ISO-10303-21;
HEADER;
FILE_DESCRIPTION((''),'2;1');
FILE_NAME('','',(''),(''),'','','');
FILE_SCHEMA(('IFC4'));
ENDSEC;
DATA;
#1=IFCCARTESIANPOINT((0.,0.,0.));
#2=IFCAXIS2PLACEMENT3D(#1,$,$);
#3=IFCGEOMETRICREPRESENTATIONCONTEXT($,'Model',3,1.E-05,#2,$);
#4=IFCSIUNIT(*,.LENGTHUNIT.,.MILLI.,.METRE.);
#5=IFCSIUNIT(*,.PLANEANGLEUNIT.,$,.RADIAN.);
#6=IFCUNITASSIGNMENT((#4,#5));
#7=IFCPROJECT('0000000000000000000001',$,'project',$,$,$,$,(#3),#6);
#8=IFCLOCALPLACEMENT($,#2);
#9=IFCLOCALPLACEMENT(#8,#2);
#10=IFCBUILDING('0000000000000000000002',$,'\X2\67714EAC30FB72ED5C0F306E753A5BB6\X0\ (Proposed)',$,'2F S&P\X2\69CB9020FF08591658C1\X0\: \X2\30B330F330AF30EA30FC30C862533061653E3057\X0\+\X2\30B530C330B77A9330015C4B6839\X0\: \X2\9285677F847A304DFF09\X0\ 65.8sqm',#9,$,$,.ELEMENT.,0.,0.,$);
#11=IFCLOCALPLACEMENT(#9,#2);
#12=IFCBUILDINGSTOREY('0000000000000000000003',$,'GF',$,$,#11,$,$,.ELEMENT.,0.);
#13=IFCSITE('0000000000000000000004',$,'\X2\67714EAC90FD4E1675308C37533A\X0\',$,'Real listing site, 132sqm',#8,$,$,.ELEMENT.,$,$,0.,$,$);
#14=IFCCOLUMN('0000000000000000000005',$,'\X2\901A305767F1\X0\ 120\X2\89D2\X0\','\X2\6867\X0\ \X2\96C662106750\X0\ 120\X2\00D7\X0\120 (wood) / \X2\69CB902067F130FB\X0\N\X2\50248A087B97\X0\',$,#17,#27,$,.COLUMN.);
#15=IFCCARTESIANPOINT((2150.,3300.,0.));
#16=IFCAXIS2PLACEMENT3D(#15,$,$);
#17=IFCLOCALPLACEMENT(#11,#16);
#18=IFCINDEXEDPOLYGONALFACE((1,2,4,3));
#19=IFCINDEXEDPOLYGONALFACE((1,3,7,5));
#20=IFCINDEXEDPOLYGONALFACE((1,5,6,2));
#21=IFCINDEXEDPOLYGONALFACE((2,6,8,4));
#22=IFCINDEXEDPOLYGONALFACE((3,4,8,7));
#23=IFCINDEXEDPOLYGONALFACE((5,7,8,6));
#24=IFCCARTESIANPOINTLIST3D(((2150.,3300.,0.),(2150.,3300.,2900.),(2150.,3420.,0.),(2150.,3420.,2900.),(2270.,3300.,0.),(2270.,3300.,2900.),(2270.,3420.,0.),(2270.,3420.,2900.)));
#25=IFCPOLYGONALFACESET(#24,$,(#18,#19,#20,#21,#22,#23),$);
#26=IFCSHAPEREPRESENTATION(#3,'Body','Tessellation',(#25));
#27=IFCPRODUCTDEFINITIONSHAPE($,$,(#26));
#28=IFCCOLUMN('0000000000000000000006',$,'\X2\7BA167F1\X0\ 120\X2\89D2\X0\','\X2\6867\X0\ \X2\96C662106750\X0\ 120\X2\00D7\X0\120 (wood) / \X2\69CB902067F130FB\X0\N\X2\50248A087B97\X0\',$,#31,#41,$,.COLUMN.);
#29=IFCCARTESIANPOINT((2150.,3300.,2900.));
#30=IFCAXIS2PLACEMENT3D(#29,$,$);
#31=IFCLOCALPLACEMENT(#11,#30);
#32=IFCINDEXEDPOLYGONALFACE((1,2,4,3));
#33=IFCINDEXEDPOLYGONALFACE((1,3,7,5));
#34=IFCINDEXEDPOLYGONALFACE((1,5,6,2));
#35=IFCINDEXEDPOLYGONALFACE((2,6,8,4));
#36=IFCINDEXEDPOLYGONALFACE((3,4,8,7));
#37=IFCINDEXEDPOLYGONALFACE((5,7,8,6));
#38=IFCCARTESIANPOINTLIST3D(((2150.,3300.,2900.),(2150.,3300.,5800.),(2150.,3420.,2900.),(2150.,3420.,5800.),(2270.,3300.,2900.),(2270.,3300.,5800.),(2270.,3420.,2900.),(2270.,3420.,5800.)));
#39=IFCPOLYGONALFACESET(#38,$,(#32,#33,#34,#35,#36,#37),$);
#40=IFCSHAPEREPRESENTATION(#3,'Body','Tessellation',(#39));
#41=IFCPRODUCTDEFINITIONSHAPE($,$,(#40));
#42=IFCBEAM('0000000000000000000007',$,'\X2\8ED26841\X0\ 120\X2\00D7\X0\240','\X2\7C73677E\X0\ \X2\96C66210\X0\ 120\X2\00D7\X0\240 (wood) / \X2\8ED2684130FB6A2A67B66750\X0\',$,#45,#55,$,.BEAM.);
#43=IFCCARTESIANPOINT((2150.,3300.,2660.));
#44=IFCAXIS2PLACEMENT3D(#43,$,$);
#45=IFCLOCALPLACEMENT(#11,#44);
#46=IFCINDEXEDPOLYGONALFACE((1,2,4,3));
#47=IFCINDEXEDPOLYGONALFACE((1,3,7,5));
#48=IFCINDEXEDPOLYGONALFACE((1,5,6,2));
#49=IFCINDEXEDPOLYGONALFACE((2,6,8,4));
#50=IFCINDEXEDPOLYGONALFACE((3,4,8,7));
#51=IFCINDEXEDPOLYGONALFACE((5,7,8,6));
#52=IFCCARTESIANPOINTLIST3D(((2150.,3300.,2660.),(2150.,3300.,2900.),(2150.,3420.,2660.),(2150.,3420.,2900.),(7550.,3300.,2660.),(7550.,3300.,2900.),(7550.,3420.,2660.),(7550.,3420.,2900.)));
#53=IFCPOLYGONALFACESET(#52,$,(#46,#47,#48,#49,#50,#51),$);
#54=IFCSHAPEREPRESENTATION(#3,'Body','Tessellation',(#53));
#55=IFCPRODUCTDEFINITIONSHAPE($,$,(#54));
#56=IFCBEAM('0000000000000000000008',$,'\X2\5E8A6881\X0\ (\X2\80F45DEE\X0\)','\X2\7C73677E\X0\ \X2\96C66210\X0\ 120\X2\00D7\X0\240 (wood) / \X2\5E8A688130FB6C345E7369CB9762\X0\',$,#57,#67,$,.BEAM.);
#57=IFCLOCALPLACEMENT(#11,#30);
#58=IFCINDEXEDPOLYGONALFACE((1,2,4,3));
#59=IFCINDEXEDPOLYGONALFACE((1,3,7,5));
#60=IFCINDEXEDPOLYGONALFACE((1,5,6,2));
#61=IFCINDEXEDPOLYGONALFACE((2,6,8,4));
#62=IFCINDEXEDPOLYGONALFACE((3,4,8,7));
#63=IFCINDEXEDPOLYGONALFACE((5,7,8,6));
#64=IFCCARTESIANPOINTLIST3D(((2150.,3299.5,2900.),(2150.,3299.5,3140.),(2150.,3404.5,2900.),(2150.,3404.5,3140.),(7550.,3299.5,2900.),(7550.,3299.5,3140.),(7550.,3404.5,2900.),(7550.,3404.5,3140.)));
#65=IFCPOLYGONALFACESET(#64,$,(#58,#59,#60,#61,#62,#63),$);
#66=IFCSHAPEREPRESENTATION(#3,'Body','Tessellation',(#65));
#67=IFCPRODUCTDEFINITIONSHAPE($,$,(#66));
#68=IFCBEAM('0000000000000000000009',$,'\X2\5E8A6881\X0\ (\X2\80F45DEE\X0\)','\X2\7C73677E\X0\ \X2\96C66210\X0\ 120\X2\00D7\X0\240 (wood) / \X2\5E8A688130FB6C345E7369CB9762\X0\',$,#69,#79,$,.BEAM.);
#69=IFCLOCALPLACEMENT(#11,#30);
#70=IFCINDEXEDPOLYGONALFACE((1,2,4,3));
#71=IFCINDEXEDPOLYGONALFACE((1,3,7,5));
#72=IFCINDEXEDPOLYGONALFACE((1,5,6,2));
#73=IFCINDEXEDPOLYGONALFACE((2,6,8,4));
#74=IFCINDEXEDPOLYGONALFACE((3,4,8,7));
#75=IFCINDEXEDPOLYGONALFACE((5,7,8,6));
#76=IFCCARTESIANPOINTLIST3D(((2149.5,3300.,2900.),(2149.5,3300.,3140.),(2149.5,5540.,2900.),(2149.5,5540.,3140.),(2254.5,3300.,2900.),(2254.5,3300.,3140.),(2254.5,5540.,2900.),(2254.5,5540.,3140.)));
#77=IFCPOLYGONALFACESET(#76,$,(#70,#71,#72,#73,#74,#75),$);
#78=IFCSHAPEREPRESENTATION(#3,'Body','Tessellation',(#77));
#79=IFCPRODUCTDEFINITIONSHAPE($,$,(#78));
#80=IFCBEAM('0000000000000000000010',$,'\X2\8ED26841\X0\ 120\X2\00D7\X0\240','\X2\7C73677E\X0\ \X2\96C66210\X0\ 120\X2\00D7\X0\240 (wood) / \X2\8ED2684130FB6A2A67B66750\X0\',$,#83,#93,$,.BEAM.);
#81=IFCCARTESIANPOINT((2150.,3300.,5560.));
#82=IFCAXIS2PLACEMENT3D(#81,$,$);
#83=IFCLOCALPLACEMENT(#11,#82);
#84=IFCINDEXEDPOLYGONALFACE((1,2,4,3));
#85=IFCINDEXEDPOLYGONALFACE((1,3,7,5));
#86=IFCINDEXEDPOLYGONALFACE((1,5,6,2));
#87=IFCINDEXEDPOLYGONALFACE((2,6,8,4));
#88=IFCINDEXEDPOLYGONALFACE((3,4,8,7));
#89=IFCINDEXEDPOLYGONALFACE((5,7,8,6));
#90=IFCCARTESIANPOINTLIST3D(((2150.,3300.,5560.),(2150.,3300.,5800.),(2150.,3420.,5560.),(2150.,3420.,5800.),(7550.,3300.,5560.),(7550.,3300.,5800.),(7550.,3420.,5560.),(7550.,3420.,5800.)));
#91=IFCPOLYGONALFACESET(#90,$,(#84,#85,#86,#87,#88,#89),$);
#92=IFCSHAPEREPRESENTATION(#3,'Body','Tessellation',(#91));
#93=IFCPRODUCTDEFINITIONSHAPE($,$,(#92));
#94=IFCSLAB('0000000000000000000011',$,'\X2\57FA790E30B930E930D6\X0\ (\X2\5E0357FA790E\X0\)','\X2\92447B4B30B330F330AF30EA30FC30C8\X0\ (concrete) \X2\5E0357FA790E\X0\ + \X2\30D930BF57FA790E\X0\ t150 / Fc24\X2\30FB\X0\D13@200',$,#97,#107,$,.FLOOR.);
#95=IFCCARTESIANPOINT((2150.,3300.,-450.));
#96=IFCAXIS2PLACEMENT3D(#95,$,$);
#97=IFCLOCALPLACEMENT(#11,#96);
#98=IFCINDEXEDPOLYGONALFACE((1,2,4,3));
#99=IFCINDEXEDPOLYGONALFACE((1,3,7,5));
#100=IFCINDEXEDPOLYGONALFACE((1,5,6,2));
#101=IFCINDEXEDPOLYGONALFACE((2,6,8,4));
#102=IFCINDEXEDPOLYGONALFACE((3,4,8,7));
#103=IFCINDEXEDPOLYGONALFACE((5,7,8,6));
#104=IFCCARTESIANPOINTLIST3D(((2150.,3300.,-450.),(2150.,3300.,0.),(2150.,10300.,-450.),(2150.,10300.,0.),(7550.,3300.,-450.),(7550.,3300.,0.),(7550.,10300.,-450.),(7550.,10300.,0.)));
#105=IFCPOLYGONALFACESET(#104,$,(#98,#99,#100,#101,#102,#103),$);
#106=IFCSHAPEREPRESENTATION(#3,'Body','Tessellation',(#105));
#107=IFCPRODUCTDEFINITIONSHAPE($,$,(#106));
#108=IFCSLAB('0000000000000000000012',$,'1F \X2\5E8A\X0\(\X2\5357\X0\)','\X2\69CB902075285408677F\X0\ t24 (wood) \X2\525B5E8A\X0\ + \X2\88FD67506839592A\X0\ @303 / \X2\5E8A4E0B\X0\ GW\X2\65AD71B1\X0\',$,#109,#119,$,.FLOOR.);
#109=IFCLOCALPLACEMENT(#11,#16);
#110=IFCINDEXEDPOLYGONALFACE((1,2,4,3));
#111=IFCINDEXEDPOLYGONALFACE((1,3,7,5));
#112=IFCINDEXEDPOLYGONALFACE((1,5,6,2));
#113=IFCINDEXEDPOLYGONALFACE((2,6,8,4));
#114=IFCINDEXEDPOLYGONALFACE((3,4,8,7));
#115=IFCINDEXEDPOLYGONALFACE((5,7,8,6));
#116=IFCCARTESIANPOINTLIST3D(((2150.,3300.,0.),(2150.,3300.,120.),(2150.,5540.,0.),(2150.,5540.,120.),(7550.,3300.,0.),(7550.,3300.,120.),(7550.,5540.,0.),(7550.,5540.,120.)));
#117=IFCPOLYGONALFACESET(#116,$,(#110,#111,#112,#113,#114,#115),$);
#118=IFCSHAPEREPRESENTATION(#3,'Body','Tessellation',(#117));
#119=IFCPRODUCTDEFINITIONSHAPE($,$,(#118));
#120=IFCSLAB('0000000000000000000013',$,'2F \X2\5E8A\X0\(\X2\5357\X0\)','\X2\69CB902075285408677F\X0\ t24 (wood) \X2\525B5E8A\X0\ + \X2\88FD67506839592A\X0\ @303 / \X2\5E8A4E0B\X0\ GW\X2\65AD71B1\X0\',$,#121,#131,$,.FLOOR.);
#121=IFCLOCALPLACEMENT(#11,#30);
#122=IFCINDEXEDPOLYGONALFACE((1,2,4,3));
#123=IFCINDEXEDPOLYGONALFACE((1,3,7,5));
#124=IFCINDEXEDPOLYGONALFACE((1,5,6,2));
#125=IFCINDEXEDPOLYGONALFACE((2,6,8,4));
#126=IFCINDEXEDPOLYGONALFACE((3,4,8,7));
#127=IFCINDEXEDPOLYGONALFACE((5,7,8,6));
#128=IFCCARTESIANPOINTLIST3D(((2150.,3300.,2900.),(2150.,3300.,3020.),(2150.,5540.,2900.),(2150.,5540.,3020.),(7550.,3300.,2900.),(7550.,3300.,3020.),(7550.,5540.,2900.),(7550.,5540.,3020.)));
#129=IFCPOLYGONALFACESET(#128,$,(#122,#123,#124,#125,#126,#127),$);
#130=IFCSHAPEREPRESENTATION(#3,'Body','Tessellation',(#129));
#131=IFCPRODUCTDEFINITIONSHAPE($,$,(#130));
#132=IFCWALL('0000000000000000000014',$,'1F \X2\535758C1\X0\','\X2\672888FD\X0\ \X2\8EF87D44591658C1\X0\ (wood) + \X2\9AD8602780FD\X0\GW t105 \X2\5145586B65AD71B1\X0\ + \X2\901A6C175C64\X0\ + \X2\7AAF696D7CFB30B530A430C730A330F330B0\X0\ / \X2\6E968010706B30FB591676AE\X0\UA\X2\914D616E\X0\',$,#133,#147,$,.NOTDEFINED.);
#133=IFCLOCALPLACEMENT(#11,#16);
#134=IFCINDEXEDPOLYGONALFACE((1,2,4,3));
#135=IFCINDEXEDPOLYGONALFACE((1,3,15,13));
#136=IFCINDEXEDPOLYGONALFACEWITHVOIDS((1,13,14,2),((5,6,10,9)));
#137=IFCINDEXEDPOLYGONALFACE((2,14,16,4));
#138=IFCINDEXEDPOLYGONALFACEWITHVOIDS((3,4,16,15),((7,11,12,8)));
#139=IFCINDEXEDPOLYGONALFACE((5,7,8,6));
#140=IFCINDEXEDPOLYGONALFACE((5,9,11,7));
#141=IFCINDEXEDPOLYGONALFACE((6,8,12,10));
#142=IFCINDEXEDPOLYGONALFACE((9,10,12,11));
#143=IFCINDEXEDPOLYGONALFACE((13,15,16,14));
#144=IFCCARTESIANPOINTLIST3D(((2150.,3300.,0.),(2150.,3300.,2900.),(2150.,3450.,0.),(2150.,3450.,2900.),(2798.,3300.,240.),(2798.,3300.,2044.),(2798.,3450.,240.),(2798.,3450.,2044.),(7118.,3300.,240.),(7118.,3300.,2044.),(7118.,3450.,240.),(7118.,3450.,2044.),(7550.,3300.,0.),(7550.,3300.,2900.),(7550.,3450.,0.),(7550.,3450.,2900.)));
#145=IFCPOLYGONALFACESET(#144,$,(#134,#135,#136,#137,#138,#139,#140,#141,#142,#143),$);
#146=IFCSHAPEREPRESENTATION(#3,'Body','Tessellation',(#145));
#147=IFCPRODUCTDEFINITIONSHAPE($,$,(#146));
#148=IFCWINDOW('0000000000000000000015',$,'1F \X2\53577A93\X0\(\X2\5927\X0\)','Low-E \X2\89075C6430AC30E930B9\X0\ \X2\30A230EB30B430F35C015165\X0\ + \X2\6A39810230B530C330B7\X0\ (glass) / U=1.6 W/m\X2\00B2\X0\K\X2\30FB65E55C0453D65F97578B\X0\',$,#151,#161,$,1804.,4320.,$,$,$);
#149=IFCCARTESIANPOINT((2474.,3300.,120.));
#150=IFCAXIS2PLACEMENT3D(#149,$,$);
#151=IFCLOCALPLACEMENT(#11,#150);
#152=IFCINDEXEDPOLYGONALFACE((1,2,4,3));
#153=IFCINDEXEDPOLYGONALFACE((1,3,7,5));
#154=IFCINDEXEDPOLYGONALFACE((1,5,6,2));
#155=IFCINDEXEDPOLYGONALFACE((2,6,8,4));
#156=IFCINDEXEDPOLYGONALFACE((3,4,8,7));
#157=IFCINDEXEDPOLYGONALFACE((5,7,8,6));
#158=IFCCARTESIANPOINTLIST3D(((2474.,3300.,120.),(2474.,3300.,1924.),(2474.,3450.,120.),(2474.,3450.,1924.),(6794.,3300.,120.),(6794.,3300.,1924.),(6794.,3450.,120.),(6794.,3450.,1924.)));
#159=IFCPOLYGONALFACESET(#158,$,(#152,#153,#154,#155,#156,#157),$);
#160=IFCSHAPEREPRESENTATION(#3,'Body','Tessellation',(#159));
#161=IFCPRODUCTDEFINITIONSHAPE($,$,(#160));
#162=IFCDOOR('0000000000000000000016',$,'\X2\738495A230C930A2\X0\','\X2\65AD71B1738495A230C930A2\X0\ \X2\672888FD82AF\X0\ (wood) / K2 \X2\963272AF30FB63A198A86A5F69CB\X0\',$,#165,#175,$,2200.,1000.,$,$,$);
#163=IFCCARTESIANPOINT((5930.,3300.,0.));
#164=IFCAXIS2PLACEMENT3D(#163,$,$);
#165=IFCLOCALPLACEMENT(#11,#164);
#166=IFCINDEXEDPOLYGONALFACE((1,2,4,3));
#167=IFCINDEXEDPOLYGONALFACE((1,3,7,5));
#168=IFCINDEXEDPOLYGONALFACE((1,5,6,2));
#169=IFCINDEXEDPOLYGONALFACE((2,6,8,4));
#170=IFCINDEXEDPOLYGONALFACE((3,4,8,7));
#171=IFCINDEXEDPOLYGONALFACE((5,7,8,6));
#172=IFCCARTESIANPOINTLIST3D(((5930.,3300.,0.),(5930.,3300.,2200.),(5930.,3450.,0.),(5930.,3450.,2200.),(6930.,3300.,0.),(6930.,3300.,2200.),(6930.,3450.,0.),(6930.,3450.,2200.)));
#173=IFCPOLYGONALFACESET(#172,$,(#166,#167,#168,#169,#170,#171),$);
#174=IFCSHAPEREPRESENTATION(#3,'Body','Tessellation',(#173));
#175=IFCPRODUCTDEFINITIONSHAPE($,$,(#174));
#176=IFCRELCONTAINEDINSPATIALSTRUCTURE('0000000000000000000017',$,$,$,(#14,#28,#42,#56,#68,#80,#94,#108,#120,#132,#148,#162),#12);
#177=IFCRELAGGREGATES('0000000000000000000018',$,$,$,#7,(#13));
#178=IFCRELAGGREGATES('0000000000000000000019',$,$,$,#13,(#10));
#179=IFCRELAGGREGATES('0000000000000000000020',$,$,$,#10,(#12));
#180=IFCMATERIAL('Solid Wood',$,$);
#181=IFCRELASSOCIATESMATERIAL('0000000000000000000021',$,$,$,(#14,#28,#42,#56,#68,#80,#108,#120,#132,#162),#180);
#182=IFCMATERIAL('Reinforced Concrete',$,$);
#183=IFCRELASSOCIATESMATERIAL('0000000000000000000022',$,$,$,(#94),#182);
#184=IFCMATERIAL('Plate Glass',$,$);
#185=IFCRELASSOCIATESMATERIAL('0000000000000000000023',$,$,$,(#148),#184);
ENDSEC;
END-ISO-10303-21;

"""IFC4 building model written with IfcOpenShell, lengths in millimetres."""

from ifc_helpers import new_model, si_unit, frame, frame_2d, origin, place, context, project, spatial, rectangle, extrude, material, element, fill, save


model = new_model("IFC4")

# Units and contexts
model_context = context("Model", 3, precision=1e-05, world=origin())
ifc_project = project(units=[si_unit("LENGTHUNIT", "METRE", prefix="MILLI"), si_unit("PLANEANGLEUNIT", "RADIAN")], contexts=[model_context])

# Site, building, storey
site_placement = place(None, origin())
site = spatial("IfcSite", under=ifc_project, at=site_placement, Name="東京都世田谷区", ObjectType="Real listing site, 132sqm", CompositionType="ELEMENT", RefElevation=0.0)
building_placement = place(site_placement, origin())
building = spatial("IfcBuilding", under=site, at=building_placement, Name="東京・狭小の町家 (Proposed)", ObjectType="2F S&P構造（外壁: コンクリート打ち放し+サッシ窓、屋根: 銅板葺き） 65.8sqm", CompositionType="ELEMENT", ElevationOfRefHeight=0.0, ElevationOfTerrain=0.0)
storey_placement = place(building_placement, origin())
storey = spatial("IfcBuildingStorey", under=building, at=storey_placement, Name="GF", CompositionType="ELEMENT", Elevation=0.0)

# Columns
ifc_material_1 = material(Name="Solid Wood")
column_1_placement = place(storey_placement, frame((2150.0, 3300.0, 0.0)))
element("IfcColumn", 1, at=column_1_placement, inside=storey, material=ifc_material_1, Name="通し柱 120角", Description="桧 集成材 120×120 (wood) / 構造柱・N値計算", PredefinedType="COLUMN", context=model_context, shape_type="SweptSolid", body=[
    extrude(rectangle(XDim=120.0, YDim=120.0, at=frame_2d((60.0, 60.0))), frame((2150.0, 3300.0, 0.0)), (0.0, 0.0, 1.0), 2900.0),
])
column_2_placement = place(storey_placement, frame((2150.0, 3300.0, 2900.0)))
element("IfcColumn", 2, at=column_2_placement, inside=storey, material=ifc_material_1, Name="管柱 120角", Description="桧 集成材 120×120 (wood) / 構造柱・N値計算", PredefinedType="COLUMN", context=model_context, shape_type="SweptSolid", body=[
    extrude(rectangle(XDim=120.0, YDim=120.0, at=frame_2d((60.0, 60.0))), frame((2150.0, 3300.0, 2900.0)), (0.0, 0.0, 1.0), 2900.0),
])

# Beams
beam_1_placement = place(storey_placement, frame((2150.0, 3300.0, 2660.0)))
element("IfcBeam", 3, at=beam_1_placement, inside=storey, material=ifc_material_1, Name="軒桁 120×240", Description="米松 集成 120×240 (wood) / 軒桁・横架材", PredefinedType="BEAM", context=model_context, shape_type="SweptSolid", body=[
    extrude(rectangle(XDim=5400.0, YDim=120.0, at=frame_2d((2700.0, 60.0))), frame((2150.0, 3300.0, 2660.0)), (0.0, 0.0, 1.0), 240.0),
])
beam_2_placement = place(storey_placement, frame((2150.0, 3300.0, 2900.0)))
element("IfcBeam", 4, at=beam_2_placement, inside=storey, material=ifc_material_1, Name="床梁 (胴差)", Description="米松 集成 120×240 (wood) / 床梁・水平構面", PredefinedType="BEAM", context=model_context, shape_type="SweptSolid", body=[
    extrude(rectangle(XDim=5400.0, YDim=105.0, at=frame_2d((2700.0, 52.0))), frame((2150.0, 3300.0, 2900.0)), (0.0, 0.0, 1.0), 240.0),
])
beam_3_placement = place(storey_placement, frame((2150.0, 3300.0, 2900.0)))
element("IfcBeam", 5, at=beam_3_placement, inside=storey, material=ifc_material_1, Name="床梁 (胴差)", Description="米松 集成 120×240 (wood) / 床梁・水平構面", PredefinedType="BEAM", context=model_context, shape_type="SweptSolid", body=[
    extrude(rectangle(XDim=105.0, YDim=2240.0, at=frame_2d((52.0, 1120.0))), frame((2150.0, 3300.0, 2900.0)), (0.0, 0.0, 1.0), 240.0),
])
beam_4_placement = place(storey_placement, frame((2150.0, 3300.0, 5560.0)))
element("IfcBeam", 6, at=beam_4_placement, inside=storey, material=ifc_material_1, Name="軒桁 120×240", Description="米松 集成 120×240 (wood) / 軒桁・横架材", PredefinedType="BEAM", context=model_context, shape_type="SweptSolid", body=[
    extrude(rectangle(XDim=5400.0, YDim=120.0, at=frame_2d((2700.0, 60.0))), frame((2150.0, 3300.0, 5560.0)), (0.0, 0.0, 1.0), 240.0),
])

# Slabs
ifc_material_2 = material(Name="Reinforced Concrete")
slab_1_placement = place(storey_placement, frame((2150.0, 3300.0, -450.0)))
element("IfcSlab", 7, at=slab_1_placement, inside=storey, material=ifc_material_2, Name="基礎スラブ (布基礎)", Description="鉄筋コンクリート (concrete) 布基礎 + ベタ基礎 t150 / Fc24・D13@200", PredefinedType="FLOOR", context=model_context, shape_type="SweptSolid", body=[
    extrude(rectangle(XDim=5400.0, YDim=7000.0, at=frame_2d((2700.0, 3500.0))), frame((2150.0, 3300.0, -450.0)), (0.0, 0.0, 1.0), 450.0),
])
slab_2_placement = place(storey_placement, frame((2150.0, 3300.0, 0.0)))
element("IfcSlab", 8, at=slab_2_placement, inside=storey, material=ifc_material_1, Name="1F 床(南)", Description="構造用合板 t24 (wood) 剛床 + 製材根太 @303 / 床下 GW断熱", PredefinedType="FLOOR", context=model_context, shape_type="SweptSolid", body=[
    extrude(rectangle(XDim=5400.0, YDim=2240.0, at=frame_2d((2700.0, 1120.0))), frame((2150.0, 3300.0, 0.0)), (0.0, 0.0, 1.0), 120.0),
])
slab_3_placement = place(storey_placement, frame((2150.0, 3300.0, 2900.0)))
element("IfcSlab", 9, at=slab_3_placement, inside=storey, material=ifc_material_1, Name="2F 床(南)", Description="構造用合板 t24 (wood) 剛床 + 製材根太 @303 / 床下 GW断熱", PredefinedType="FLOOR", context=model_context, shape_type="SweptSolid", body=[
    extrude(rectangle(XDim=5400.0, YDim=2240.0, at=frame_2d((2700.0, 1120.0))), frame((2150.0, 3300.0, 2900.0)), (0.0, 0.0, 1.0), 120.0),
])

# Wall, openings, window, door
wall_1_placement = place(storey_placement, frame((2150.0, 3300.0, 0.0)))
wall_1 = element("IfcWall", 10, at=wall_1_placement, inside=storey, material=ifc_material_1, Name="1F 南壁", Description="木製 軸組外壁 (wood) + 高性能GW t105 充填断熱 + 通気層 + 窯業系サイディング / 準耐火・外皮UA配慮", PredefinedType="NOTDEFINED", context=model_context, shape_type="SweptSolid", body=[
    extrude(rectangle(XDim=5400.0, YDim=150.0, at=frame_2d((2700.0, 75.0))), frame((2150.0, 3300.0, 0.0)), (0.0, 0.0, 1.0), 2900.0),
])
opening_1_placement = place(storey_placement, frame((2474.0, 3300.0, 120.0)))
opening_1 = element("IfcOpeningElement", 11, at=opening_1_placement, cuts=wall_1, PredefinedType="NOTDEFINED", context=model_context, shape_type="SweptSolid", body=[
    extrude(rectangle(XDim=4320.0, YDim=150.0, at=frame_2d((2160.0, 75.0))), frame((2474.0, 3300.0, 120.0)), (0.0, 0.0, 1.0), 1804.0),
])
opening_2_placement = place(storey_placement, frame((5930.0, 3300.0, 0.0)))
opening_2 = element("IfcOpeningElement", 12, at=opening_2_placement, cuts=wall_1, PredefinedType="NOTDEFINED", context=model_context, shape_type="SweptSolid", body=[
    extrude(rectangle(XDim=1000.0, YDim=150.0, at=frame_2d((500.0, 75.0))), frame((5930.0, 3300.0, 0.0)), (0.0, 0.0, 1.0), 2200.0),
])
ifc_material_3 = material(Name="Plate Glass")
window_1_placement = place(storey_placement, frame((2474.0, 3300.0, 120.0)))
window_1 = element("IfcWindow", 13, at=window_1_placement, inside=storey, material=ifc_material_3, Name="1F 南窓(大)", Description="Low-E 複層ガラス アルゴン封入 + 樹脂サッシ (glass) / U=1.6 W/m²K・日射取得型", OverallHeight=1804.0, OverallWidth=4320.0, context=model_context, shape_type="SweptSolid", body=[
    extrude(rectangle(XDim=4320.0, YDim=150.0, at=frame_2d((2160.0, 75.0))), frame((2474.0, 3300.0, 120.0)), (0.0, 0.0, 1.0), 1804.0),
])
fill(opening_1, window_1)
door_placement = place(storey_placement, frame((5930.0, 3300.0, 0.0)))
door = element("IfcDoor", 14, at=door_placement, inside=storey, material=ifc_material_1, Name="玄関ドア", Description="断熱玄関ドア 木製芯 (wood) / K2 防犯・採風機構", OverallHeight=2200.0, OverallWidth=1000.0, context=model_context, shape_type="SweptSolid", body=[
    extrude(rectangle(XDim=1000.0, YDim=150.0, at=frame_2d((500.0, 75.0))), frame((5930.0, 3300.0, 0.0)), (0.0, 0.0, 1.0), 2200.0),
])
fill(opening_2, door)

save(model, "model.ifc")
